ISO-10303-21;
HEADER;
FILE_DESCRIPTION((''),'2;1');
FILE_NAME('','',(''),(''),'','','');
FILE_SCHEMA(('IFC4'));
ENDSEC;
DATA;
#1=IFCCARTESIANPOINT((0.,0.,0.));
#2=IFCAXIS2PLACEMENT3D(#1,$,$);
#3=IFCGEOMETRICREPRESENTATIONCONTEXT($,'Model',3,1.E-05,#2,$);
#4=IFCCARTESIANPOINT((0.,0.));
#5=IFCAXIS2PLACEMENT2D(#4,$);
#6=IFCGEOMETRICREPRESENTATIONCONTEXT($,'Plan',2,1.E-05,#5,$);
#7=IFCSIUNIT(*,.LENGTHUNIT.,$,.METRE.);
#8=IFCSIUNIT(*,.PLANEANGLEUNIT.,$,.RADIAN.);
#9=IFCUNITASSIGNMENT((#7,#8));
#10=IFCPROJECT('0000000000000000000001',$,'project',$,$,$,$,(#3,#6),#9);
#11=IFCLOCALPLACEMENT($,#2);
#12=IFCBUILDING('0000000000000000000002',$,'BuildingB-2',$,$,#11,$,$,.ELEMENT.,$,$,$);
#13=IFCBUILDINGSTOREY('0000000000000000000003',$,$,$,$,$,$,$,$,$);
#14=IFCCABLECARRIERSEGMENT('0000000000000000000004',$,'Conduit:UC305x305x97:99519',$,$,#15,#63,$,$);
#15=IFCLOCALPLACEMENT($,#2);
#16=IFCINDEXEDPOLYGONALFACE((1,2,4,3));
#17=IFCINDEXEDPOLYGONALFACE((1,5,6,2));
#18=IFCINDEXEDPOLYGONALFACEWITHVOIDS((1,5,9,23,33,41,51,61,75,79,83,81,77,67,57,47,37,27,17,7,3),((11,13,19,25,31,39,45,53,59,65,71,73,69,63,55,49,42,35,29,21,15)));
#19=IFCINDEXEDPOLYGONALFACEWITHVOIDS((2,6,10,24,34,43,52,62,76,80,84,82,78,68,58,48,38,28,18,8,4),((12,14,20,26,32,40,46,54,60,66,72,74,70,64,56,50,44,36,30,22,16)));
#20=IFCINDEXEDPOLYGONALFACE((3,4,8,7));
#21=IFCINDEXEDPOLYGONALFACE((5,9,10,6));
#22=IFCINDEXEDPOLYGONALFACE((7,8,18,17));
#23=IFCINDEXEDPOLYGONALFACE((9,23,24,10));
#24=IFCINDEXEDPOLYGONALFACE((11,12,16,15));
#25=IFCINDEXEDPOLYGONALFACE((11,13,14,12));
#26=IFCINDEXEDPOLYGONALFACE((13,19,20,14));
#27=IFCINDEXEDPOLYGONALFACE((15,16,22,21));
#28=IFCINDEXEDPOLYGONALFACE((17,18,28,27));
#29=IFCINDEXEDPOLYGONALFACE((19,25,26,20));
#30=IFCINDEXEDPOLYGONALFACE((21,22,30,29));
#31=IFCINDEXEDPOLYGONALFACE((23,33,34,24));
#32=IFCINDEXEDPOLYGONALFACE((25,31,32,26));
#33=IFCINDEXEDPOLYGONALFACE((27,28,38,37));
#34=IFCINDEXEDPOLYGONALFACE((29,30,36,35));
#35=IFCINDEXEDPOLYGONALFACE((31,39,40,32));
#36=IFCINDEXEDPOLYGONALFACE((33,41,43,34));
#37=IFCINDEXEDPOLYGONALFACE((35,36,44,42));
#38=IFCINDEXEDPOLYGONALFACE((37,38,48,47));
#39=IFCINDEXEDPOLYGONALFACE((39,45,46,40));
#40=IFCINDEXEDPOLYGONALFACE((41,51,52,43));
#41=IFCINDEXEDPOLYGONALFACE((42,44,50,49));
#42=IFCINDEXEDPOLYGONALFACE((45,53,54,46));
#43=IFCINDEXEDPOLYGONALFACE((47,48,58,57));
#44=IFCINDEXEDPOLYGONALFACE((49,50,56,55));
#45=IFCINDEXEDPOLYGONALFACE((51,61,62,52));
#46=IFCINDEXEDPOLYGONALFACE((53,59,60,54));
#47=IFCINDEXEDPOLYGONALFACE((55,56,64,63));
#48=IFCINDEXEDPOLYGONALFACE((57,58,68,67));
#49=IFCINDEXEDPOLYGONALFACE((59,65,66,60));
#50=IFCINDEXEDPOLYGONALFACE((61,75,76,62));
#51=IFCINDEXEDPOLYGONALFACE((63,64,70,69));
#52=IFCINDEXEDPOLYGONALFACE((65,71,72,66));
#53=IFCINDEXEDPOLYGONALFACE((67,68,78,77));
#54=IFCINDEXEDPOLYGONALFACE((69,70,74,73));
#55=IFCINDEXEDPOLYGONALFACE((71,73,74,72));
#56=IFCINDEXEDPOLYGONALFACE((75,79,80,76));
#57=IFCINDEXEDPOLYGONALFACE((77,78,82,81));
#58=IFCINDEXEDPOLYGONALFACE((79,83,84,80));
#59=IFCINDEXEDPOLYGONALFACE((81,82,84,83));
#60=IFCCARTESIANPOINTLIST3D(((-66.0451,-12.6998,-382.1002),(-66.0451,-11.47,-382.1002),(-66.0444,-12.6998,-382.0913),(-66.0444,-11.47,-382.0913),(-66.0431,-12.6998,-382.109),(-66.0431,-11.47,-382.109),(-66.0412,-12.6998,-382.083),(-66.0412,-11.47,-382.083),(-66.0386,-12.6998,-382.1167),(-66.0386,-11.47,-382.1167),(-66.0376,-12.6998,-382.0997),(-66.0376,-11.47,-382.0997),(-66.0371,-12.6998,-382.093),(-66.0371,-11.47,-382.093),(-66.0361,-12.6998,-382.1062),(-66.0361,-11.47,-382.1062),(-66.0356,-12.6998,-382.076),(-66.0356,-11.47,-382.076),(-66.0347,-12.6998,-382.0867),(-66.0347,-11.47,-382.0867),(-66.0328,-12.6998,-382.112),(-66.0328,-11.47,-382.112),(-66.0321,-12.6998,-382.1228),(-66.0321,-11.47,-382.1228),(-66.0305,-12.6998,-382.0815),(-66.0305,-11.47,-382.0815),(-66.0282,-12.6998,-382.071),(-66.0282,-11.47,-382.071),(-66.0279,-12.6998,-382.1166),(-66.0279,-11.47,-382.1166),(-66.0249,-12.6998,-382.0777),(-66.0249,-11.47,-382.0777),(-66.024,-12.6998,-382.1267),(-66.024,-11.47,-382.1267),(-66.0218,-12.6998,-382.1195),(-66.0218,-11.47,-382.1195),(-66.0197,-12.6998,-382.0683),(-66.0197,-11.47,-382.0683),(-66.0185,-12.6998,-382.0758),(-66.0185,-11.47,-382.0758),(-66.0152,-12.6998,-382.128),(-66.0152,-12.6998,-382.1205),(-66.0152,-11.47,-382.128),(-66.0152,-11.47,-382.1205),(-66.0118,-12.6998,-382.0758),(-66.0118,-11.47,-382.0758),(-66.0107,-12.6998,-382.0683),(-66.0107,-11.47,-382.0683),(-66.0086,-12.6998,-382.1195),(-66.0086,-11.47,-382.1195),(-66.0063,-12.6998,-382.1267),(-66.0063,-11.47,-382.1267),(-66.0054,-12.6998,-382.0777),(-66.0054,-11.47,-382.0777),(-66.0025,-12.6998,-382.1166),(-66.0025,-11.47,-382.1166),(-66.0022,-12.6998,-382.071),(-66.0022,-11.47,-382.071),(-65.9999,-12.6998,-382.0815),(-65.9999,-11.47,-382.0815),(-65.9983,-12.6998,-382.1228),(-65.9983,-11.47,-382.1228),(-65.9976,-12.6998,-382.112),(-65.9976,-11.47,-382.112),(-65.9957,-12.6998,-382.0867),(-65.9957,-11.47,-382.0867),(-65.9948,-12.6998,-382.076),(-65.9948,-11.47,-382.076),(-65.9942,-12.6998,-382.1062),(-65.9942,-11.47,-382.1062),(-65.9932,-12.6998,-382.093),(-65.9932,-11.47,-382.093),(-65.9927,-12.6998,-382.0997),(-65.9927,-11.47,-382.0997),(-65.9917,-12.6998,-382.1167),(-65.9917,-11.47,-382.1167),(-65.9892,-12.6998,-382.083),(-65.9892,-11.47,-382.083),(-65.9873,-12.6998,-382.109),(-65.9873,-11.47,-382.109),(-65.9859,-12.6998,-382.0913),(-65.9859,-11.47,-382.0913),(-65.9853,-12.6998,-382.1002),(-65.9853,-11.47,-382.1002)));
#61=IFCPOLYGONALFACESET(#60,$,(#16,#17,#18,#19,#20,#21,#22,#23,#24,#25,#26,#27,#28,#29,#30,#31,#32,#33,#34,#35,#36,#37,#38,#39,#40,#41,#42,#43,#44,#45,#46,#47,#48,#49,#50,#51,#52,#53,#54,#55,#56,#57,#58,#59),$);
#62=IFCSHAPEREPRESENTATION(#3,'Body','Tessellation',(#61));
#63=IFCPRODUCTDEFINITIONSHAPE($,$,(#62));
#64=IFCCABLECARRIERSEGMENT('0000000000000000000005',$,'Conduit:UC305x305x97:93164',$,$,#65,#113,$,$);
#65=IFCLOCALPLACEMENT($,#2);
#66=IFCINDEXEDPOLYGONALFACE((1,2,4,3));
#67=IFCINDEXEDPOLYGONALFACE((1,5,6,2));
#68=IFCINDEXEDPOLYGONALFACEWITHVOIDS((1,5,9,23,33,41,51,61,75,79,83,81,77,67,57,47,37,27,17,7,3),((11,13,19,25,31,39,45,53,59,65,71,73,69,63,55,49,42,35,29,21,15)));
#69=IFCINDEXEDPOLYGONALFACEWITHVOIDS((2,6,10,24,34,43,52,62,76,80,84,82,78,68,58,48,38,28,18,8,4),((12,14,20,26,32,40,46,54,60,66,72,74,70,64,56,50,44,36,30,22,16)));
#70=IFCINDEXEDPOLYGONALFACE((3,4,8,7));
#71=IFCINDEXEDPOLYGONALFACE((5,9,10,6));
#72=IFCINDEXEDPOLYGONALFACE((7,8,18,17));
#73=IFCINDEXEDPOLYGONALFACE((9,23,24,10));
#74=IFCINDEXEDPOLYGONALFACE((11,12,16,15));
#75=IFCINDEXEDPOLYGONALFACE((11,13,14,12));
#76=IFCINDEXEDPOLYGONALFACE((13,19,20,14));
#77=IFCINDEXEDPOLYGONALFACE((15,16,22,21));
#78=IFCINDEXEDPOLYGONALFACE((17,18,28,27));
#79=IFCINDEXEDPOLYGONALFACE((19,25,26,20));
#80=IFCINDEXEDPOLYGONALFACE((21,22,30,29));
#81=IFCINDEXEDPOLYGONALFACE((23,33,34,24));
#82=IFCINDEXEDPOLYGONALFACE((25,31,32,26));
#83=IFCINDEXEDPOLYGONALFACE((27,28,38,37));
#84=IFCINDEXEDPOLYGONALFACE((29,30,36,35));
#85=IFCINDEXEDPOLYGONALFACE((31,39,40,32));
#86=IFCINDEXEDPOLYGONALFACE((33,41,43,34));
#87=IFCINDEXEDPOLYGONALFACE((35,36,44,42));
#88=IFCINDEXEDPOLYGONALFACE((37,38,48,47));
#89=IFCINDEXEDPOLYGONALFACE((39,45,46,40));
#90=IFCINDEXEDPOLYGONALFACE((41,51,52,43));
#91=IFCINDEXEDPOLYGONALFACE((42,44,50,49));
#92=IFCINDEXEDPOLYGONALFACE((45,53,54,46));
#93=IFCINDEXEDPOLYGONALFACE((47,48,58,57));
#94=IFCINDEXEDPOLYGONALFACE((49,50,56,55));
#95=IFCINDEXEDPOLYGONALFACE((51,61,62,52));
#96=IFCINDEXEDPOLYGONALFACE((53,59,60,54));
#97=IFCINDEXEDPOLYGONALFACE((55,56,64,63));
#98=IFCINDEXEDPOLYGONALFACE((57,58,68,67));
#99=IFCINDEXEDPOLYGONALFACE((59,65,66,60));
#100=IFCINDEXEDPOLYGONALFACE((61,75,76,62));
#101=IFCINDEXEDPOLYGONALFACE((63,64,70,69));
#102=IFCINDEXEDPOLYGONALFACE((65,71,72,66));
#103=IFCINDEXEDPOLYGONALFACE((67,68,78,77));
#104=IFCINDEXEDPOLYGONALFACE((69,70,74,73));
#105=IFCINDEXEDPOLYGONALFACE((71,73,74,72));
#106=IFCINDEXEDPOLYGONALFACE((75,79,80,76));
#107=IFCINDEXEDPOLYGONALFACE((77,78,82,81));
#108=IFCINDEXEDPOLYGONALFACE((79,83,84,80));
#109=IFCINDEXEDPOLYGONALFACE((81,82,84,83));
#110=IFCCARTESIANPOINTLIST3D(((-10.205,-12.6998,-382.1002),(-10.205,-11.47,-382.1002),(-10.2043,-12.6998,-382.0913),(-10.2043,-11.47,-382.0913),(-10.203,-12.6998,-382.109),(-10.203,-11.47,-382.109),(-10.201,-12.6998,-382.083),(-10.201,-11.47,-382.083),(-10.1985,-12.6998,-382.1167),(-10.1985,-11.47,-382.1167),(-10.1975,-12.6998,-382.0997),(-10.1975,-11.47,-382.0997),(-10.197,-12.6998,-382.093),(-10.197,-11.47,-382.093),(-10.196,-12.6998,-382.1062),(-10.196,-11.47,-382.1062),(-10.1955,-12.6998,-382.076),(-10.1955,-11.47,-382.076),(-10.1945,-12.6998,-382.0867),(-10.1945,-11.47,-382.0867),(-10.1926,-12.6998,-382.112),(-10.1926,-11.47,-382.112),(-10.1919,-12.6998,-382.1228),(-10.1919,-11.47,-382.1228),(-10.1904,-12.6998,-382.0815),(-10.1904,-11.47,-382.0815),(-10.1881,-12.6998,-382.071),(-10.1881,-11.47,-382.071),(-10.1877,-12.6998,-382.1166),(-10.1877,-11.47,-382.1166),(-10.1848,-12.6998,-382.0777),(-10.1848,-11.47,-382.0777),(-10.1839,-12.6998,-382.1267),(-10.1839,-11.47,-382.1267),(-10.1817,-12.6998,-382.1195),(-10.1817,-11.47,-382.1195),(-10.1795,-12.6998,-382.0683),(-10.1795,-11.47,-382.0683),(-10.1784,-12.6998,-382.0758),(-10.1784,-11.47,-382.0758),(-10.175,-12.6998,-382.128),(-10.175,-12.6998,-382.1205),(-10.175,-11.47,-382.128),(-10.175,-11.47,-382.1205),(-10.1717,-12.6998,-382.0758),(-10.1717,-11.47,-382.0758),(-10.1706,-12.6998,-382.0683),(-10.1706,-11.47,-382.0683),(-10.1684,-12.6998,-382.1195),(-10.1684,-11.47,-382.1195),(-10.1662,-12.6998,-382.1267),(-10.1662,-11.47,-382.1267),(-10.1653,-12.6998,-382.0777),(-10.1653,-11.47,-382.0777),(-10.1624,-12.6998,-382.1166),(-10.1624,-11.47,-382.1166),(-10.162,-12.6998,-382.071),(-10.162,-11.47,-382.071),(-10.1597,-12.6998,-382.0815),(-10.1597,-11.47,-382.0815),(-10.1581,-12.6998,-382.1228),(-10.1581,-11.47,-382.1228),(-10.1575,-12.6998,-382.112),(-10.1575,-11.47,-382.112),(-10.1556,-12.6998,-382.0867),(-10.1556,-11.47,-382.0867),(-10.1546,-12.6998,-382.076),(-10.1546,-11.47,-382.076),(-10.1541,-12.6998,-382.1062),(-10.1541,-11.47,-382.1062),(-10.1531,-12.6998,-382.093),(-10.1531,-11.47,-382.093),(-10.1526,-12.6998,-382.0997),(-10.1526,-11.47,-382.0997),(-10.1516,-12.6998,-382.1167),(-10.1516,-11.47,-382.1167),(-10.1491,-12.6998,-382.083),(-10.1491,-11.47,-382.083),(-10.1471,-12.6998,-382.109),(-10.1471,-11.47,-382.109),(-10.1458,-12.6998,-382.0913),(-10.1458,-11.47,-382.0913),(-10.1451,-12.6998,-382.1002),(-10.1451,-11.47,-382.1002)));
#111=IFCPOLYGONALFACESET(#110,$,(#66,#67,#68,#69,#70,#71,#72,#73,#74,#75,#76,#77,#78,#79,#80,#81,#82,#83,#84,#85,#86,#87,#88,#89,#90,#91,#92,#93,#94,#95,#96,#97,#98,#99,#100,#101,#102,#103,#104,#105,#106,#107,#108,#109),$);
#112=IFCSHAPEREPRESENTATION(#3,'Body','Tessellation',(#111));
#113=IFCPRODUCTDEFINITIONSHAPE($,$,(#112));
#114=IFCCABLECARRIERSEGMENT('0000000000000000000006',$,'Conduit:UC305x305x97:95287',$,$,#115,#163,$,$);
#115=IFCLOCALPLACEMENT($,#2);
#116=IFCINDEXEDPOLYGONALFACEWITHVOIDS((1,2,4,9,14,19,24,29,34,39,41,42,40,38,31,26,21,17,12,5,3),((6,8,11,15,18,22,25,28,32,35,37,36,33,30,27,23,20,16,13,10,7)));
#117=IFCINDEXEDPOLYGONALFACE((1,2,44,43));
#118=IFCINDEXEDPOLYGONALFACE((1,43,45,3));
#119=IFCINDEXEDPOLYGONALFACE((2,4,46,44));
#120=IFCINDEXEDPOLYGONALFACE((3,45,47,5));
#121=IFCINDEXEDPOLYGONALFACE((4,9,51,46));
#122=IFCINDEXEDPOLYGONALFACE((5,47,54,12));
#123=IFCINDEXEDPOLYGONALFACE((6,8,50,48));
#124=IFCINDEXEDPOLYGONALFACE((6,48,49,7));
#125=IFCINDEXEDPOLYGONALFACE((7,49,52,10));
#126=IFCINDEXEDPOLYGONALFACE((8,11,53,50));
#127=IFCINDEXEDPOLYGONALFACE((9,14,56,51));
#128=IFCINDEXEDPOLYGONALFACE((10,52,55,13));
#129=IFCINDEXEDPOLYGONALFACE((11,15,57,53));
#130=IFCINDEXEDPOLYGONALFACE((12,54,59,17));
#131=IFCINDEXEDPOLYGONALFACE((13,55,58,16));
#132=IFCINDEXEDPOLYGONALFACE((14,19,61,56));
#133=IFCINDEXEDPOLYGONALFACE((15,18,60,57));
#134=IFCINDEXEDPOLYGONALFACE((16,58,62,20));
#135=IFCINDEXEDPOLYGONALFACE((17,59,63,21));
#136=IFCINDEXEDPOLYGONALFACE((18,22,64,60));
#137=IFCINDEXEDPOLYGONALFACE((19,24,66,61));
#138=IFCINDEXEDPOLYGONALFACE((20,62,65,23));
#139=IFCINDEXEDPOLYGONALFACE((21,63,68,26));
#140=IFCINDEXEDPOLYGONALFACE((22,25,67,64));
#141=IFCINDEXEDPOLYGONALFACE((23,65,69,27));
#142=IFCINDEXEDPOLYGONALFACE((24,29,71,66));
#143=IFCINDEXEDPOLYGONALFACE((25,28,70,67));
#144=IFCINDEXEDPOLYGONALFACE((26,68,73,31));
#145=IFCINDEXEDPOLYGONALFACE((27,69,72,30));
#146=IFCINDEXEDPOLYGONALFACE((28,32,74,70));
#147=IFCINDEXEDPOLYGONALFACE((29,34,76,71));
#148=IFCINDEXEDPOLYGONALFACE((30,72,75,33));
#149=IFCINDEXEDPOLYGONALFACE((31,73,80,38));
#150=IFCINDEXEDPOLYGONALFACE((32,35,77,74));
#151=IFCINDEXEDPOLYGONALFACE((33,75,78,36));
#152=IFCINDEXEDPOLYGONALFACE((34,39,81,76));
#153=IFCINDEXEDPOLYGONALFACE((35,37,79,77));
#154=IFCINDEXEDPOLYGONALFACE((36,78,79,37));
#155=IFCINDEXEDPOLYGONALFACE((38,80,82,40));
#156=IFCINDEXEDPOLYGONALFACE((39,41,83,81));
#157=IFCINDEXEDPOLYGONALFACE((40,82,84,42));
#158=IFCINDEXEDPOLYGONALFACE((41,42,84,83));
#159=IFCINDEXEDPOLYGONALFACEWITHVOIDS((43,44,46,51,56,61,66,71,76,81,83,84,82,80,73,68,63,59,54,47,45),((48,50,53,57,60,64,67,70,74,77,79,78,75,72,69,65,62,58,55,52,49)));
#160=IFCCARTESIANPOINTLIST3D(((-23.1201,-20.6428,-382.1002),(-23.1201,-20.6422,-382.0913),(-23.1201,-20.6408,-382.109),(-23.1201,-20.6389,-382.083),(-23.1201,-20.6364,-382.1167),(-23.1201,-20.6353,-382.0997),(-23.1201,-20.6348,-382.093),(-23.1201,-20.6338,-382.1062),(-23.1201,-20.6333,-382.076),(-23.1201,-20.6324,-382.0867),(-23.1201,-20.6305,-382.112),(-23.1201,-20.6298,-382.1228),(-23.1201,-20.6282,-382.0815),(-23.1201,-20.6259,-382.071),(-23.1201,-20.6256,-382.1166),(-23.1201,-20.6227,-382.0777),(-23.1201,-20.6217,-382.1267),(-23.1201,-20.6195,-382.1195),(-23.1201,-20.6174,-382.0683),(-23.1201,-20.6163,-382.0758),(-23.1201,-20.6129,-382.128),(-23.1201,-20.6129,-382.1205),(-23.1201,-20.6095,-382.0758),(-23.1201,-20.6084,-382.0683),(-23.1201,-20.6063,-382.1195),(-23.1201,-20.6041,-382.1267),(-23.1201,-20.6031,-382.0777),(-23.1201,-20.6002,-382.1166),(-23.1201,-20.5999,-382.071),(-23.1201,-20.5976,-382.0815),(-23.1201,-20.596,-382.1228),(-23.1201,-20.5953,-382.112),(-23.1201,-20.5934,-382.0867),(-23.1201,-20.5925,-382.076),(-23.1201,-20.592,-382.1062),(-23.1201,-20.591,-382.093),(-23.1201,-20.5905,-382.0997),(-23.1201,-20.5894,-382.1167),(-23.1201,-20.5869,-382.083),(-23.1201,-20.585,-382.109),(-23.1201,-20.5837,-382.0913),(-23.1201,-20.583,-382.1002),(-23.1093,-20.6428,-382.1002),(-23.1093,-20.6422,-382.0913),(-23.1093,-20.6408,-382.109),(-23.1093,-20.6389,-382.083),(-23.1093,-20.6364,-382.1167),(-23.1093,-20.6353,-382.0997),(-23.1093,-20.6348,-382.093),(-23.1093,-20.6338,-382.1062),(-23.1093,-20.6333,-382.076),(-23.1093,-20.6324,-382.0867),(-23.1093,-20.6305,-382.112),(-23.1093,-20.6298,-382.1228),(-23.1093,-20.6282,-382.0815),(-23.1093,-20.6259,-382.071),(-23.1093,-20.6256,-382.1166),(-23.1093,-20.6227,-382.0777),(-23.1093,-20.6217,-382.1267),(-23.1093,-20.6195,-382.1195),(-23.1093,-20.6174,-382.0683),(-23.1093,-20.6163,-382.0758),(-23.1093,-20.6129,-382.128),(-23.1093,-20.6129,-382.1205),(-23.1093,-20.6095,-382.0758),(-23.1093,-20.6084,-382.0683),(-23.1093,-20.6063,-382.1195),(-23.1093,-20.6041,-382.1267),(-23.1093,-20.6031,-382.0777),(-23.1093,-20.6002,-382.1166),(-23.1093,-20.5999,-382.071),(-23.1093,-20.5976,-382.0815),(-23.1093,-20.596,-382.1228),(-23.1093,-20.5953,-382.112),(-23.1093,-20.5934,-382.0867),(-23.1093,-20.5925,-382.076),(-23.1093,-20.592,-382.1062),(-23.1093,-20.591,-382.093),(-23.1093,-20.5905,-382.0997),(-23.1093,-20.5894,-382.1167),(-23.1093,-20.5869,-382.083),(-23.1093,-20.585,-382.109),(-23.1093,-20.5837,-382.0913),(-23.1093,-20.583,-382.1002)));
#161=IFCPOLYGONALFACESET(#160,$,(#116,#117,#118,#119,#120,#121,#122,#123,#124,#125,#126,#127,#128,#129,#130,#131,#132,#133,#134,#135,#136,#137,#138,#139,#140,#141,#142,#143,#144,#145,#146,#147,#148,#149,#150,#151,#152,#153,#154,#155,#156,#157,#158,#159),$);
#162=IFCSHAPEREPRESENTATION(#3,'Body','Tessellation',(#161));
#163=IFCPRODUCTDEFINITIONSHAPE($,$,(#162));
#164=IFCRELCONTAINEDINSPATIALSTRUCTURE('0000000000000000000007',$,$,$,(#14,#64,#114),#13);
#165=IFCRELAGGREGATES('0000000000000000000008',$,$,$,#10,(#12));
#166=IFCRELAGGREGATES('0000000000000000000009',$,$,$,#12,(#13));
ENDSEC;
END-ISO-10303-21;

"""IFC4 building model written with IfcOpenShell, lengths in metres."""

from ifc_helpers import new_model, entity, si_unit, origin, origin_2d, place, context, project, spatial, element, save


model = new_model("IFC4")

# Units and contexts
model_context = context("Model", 3, precision=1e-05, world=origin())
plan_context = context("Plan", 2, precision=1e-05, world=origin_2d())
ifc_project = project(units=[si_unit("LENGTHUNIT", "METRE"), si_unit("PLANEANGLEUNIT", "RADIAN")], contexts=[model_context, plan_context])

# Building, storey
building_placement = place(None, origin())
building = spatial("IfcBuilding", under=ifc_project, at=building_placement, Name="BuildingB-2", CompositionType="ELEMENT")
storey = spatial("IfcBuildingStorey", under=building)

# Cable carrier segments
element("IfcCableCarrierSegment", 1, inside=storey, Name="Conduit:UC305x305x97:99519", context=model_context, shape_type="AdvancedSweptSolid", body=[
    entity("IfcSweptDiskSolid", entity("IfcCompositeCurve", [entity("IfcCompositeCurveSegment", "CONTINUOUS", False, entity("IfcPolyline", [entity("IfcCartesianPoint", [66.0152, 12.6998, 382.098]), entity("IfcCartesianPoint", [66.0152, 11.47, 382.098])]))], False), 0.03, 0.0225),
])
element("IfcCableCarrierSegment", 2, inside=storey, Name="Conduit:UC305x305x97:93164", context=model_context, shape_type="AdvancedSweptSolid", body=[
    entity("IfcSweptDiskSolid", entity("IfcCompositeCurve", [entity("IfcCompositeCurveSegment", "CONTINUOUS", False, entity("IfcPolyline", [entity("IfcCartesianPoint", [10.175, 12.6998, 382.098]), entity("IfcCartesianPoint", [10.175, 11.47, 382.098])]))], False), 0.03, 0.0225),
])
element("IfcCableCarrierSegment", 3, inside=storey, Name="Conduit:UC305x305x97:95287", context=model_context, shape_type="AdvancedSweptSolid", body=[
    entity("IfcSweptDiskSolid", entity("IfcCompositeCurve", [entity("IfcCompositeCurveSegment", "CONTINUOUS", False, entity("IfcPolyline", [entity("IfcCartesianPoint", [23.1201, 20.6129, 382.098]), entity("IfcCartesianPoint", [23.1093, 20.6129, 382.098])]))], False), 0.03, 0.0225),
])

save(model, "model.ifc")
